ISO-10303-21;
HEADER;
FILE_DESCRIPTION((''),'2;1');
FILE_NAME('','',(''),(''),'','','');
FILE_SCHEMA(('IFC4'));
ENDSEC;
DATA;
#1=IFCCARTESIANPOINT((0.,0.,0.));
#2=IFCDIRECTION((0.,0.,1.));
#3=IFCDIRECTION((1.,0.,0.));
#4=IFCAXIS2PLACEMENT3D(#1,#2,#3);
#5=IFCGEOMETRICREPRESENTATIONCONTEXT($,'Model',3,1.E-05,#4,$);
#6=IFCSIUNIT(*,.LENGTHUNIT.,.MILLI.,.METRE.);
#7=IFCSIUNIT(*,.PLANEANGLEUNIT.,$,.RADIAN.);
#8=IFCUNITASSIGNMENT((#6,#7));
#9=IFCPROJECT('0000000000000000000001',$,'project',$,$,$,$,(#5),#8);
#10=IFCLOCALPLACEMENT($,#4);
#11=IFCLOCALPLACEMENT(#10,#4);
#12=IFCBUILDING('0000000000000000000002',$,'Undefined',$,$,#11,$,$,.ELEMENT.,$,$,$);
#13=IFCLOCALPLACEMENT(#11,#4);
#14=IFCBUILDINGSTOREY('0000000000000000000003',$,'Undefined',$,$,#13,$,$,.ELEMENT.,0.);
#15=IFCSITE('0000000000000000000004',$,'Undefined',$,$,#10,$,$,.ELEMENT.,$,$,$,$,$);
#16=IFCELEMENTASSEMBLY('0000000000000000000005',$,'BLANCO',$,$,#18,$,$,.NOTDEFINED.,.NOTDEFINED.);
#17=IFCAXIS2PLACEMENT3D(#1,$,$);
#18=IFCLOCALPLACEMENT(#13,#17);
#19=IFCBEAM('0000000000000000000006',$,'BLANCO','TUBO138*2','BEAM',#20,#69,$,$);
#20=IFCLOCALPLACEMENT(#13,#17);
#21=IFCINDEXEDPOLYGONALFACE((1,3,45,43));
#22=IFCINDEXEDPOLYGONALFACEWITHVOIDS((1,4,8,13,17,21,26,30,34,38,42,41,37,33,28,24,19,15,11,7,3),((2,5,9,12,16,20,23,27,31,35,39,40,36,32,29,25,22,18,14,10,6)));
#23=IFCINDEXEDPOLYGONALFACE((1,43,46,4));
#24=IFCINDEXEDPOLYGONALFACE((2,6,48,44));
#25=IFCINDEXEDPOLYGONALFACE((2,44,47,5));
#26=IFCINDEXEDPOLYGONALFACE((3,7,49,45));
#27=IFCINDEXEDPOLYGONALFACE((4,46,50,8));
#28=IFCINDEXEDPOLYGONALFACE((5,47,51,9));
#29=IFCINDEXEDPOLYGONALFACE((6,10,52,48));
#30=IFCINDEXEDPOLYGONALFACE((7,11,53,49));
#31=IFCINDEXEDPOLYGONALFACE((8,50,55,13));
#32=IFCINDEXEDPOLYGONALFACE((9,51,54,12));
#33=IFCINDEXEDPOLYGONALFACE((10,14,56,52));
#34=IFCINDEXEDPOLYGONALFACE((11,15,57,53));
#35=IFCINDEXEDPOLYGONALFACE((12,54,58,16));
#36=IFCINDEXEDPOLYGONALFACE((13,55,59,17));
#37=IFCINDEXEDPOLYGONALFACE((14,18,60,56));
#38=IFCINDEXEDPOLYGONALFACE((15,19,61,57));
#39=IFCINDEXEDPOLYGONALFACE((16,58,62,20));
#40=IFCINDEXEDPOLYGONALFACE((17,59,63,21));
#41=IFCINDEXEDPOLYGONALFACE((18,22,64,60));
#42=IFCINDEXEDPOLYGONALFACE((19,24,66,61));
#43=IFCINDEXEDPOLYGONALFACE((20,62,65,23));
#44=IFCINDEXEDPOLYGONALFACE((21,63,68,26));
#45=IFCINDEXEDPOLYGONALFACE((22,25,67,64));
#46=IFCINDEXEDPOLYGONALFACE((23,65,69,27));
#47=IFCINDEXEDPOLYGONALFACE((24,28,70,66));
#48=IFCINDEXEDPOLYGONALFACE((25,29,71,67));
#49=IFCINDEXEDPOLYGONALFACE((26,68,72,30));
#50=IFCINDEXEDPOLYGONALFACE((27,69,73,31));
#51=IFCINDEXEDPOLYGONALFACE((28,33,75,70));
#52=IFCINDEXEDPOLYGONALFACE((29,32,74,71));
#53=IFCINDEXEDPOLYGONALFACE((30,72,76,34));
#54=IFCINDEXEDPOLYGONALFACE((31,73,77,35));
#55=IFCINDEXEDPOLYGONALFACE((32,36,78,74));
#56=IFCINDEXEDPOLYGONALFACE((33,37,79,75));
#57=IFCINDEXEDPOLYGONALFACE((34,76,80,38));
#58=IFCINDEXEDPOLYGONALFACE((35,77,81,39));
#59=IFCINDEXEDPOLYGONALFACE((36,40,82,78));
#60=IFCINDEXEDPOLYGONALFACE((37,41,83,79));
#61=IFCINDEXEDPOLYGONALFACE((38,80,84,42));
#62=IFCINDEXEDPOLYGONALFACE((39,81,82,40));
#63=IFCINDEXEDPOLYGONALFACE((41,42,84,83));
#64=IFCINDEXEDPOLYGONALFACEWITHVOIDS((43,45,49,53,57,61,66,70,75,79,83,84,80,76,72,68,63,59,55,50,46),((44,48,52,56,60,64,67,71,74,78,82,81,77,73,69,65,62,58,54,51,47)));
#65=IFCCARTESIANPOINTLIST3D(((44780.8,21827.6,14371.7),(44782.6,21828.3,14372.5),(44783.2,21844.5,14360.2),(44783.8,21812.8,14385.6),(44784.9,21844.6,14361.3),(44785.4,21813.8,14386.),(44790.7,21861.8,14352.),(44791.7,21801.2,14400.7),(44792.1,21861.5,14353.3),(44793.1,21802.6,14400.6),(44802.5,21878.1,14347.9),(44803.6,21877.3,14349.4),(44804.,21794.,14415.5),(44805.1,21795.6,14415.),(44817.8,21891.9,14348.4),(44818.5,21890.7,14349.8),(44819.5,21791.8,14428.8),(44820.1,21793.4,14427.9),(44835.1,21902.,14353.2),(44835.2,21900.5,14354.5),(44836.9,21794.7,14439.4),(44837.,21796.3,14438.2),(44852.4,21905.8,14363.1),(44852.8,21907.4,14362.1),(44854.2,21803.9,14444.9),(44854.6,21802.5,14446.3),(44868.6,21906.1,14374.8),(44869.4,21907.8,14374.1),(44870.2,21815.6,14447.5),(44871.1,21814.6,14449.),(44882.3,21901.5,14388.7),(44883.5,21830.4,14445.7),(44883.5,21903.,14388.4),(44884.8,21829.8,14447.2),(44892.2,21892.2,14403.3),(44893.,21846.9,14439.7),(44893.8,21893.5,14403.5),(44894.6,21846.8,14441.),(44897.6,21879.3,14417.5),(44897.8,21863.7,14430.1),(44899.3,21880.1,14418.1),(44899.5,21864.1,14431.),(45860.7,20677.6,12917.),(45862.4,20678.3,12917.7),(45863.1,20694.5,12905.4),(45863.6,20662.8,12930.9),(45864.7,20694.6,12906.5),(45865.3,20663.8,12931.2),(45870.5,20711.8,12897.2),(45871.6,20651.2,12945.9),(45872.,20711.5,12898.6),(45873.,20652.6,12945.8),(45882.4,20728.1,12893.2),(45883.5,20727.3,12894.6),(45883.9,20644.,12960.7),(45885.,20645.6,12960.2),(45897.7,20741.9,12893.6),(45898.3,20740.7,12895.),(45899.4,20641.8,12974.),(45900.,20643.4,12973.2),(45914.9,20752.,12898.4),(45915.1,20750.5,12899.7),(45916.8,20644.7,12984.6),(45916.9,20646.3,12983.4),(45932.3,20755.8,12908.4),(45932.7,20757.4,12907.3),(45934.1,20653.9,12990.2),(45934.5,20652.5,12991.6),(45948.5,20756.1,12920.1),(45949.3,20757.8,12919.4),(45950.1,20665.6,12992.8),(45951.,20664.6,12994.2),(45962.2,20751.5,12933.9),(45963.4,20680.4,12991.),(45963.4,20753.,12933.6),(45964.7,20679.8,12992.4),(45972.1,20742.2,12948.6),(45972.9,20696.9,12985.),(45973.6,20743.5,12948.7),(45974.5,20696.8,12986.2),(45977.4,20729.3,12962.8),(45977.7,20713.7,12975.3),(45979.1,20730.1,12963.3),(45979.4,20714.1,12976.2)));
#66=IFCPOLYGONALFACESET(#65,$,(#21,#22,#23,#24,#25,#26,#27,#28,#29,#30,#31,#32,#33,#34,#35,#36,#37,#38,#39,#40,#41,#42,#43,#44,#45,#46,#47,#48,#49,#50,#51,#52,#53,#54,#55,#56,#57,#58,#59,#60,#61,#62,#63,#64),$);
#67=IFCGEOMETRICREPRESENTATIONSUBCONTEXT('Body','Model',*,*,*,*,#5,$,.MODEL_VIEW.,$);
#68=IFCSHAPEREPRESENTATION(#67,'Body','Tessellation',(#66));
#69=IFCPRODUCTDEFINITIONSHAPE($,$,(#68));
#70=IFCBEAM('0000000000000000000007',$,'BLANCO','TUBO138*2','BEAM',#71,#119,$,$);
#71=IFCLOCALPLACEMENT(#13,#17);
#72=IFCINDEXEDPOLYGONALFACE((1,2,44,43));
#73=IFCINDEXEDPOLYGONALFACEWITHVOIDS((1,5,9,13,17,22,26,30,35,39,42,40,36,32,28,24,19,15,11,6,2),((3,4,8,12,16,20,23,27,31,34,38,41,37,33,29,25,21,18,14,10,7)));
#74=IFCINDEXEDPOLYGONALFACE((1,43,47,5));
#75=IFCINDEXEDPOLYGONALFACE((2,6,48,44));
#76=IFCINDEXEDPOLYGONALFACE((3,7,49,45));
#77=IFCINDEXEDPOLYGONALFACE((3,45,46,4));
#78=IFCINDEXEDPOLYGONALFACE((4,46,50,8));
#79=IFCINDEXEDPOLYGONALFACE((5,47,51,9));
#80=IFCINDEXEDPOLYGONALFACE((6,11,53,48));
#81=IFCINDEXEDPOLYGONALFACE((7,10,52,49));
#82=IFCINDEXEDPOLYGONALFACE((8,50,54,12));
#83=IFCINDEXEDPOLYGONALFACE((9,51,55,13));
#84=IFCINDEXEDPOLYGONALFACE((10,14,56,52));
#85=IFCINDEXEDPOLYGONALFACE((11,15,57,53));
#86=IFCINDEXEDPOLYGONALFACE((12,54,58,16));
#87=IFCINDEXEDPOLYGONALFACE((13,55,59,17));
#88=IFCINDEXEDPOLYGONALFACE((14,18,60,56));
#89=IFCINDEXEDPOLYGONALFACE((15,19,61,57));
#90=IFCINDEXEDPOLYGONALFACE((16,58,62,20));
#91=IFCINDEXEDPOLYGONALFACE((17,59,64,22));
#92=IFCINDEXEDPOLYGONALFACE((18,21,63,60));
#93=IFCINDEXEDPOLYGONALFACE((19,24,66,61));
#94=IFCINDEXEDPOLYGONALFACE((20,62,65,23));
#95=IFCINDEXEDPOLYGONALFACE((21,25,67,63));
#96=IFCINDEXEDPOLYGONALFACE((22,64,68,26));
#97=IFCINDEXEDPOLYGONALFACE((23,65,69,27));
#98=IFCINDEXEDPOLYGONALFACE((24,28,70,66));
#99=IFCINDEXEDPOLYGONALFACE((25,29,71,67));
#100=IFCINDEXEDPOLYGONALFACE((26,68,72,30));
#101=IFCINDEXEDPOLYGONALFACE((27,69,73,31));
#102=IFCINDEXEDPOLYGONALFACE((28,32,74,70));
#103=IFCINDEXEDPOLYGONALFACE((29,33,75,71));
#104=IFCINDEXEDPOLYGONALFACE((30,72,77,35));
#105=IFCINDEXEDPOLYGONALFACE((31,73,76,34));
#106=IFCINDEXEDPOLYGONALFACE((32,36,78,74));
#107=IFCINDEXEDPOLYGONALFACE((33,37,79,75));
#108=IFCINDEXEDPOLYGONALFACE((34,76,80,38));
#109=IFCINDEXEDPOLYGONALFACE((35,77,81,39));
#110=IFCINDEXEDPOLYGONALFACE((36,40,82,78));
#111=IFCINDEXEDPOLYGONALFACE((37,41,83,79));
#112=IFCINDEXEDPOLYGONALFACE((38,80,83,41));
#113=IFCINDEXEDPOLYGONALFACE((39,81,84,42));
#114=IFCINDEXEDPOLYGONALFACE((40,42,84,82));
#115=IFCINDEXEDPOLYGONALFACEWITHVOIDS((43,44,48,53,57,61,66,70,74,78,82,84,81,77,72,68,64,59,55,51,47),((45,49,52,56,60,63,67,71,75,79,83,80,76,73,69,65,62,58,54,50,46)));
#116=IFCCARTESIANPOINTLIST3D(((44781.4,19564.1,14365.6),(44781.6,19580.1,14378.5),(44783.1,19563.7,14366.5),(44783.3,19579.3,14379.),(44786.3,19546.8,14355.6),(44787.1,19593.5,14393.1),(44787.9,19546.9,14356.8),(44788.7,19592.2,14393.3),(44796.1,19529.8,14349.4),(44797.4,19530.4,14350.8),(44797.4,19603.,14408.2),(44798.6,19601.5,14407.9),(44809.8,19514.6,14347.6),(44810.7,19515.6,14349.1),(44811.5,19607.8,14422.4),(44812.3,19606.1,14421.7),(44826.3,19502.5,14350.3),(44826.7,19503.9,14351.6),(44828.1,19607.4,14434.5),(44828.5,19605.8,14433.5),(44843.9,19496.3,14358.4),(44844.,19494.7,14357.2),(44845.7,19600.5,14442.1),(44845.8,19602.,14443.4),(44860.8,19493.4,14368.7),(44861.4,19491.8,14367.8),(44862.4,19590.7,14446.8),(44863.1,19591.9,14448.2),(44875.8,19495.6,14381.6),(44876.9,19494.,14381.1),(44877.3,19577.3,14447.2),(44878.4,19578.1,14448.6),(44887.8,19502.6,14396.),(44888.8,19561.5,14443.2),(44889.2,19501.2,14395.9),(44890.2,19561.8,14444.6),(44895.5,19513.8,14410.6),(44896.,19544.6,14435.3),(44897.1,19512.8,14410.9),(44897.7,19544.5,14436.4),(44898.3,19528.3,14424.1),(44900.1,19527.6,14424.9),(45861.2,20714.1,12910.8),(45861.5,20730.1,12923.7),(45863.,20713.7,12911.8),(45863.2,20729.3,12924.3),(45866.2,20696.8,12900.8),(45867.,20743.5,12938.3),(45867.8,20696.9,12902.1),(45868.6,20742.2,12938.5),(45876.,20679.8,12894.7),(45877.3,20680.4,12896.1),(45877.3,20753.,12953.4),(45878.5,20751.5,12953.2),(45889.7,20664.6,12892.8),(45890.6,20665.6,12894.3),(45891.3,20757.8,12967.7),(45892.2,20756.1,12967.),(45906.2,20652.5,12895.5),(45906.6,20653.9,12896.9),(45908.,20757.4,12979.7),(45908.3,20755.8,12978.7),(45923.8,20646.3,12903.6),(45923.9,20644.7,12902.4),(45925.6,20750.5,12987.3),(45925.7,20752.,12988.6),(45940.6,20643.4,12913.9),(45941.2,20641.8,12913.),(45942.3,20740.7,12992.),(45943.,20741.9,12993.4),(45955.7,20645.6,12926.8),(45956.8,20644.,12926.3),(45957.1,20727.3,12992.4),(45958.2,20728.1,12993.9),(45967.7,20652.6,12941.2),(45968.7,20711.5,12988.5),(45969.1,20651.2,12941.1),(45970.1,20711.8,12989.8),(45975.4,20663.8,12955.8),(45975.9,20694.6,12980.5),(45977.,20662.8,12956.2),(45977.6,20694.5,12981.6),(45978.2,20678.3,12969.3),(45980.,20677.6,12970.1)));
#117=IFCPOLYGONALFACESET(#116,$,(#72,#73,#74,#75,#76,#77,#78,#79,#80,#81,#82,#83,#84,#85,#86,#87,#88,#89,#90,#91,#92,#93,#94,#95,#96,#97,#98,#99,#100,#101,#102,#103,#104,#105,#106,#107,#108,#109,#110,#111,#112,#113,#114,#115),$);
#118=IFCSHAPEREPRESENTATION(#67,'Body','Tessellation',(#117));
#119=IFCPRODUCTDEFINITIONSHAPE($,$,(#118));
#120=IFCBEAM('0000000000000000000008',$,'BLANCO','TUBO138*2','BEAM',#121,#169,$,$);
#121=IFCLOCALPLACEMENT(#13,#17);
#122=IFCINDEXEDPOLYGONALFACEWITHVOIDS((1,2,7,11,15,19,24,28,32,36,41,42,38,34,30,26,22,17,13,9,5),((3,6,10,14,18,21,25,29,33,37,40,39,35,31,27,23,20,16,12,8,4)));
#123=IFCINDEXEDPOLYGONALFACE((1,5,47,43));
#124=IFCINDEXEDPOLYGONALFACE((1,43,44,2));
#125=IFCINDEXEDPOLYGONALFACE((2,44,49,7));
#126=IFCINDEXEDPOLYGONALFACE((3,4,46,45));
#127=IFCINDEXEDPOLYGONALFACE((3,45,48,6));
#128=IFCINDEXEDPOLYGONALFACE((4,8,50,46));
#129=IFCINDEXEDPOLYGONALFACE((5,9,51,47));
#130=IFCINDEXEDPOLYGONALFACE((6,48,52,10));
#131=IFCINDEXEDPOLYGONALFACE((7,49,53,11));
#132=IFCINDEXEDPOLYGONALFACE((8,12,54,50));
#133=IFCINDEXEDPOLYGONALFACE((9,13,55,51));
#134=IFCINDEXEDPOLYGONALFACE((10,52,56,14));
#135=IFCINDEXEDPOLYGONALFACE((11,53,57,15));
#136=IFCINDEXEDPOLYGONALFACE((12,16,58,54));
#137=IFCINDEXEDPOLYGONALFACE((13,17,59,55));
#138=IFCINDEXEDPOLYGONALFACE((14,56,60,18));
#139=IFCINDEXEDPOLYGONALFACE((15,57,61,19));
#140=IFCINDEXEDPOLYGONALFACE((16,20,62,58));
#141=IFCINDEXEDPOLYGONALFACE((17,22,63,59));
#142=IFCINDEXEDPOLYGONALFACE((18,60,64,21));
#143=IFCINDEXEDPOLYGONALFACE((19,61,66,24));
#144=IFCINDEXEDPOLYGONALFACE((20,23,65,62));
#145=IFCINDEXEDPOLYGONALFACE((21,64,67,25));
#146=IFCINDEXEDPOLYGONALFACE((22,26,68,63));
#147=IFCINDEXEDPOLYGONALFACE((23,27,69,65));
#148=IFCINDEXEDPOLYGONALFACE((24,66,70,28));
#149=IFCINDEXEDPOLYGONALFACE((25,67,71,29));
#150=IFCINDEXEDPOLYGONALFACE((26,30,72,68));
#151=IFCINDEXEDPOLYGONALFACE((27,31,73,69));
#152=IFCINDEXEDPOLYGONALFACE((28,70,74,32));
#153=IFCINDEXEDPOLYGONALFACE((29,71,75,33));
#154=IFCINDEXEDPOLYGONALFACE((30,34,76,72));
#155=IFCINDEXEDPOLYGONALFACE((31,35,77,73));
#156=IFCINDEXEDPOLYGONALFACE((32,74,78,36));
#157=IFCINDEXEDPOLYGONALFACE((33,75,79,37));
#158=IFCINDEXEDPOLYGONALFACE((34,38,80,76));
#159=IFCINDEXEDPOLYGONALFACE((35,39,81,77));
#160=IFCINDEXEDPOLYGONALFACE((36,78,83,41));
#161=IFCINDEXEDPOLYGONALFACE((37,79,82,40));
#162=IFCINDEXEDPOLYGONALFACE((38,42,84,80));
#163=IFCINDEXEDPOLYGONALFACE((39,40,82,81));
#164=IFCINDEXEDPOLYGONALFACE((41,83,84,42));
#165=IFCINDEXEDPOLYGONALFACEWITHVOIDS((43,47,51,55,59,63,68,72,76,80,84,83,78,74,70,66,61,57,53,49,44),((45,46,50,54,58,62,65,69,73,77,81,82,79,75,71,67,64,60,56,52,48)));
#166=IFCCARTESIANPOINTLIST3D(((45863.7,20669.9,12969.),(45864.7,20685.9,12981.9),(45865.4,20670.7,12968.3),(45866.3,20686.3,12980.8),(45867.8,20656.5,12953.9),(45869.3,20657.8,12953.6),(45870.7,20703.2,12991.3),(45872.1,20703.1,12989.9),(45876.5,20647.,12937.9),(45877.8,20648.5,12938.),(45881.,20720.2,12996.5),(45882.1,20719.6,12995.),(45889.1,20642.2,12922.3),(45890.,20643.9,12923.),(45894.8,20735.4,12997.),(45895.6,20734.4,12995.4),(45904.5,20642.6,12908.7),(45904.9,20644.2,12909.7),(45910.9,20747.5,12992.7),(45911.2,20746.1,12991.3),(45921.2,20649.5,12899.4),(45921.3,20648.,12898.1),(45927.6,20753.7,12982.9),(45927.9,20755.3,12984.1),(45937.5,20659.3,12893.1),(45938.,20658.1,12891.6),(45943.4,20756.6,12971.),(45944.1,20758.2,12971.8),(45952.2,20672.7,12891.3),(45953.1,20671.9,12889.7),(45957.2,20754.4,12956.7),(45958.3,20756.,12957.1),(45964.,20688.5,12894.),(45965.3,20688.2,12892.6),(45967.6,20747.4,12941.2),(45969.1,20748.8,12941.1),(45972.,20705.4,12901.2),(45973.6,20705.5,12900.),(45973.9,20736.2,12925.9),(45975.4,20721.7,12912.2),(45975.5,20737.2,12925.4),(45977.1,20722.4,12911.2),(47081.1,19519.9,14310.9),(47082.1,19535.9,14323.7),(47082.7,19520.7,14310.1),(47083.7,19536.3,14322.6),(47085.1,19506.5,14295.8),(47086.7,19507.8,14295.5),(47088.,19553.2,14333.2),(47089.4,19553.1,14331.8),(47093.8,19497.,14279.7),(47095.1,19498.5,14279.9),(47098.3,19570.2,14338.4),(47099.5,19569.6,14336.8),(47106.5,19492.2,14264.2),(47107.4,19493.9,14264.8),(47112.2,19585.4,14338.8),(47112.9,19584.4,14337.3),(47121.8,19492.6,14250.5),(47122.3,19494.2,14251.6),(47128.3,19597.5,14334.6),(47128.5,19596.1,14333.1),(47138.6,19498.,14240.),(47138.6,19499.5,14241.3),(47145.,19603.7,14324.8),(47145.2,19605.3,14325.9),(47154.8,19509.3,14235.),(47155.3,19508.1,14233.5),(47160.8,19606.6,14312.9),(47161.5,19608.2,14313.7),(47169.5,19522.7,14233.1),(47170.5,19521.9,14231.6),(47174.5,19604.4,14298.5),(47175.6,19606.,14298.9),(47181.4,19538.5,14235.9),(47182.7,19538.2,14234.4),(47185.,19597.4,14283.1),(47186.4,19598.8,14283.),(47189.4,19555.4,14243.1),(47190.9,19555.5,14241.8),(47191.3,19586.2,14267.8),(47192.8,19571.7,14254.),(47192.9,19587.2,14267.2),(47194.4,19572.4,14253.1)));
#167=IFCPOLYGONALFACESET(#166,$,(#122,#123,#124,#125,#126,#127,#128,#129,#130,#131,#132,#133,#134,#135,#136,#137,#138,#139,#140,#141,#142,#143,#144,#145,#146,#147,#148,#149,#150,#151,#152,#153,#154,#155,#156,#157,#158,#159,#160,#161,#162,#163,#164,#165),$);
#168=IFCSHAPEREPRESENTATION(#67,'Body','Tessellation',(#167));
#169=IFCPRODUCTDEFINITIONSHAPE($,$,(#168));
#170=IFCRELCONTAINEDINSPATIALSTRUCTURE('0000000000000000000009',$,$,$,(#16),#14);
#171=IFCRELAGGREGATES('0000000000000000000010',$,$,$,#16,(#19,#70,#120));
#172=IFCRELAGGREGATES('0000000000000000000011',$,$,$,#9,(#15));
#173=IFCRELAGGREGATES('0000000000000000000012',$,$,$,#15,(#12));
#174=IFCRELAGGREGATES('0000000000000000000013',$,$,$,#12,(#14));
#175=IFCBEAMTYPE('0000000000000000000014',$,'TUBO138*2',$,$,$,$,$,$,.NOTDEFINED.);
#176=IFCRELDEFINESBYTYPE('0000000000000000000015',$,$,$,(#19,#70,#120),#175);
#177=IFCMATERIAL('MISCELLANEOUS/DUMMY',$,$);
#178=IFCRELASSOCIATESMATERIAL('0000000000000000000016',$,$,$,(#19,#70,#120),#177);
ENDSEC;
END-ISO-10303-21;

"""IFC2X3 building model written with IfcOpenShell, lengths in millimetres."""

from ifc_helpers import new_model, si_unit, frame, origin_with_axes, origin_2d_with_axis, place, context, subcontext, project, spatial, hollow_circle, extrude, material, type_object, element, aggregate, save


model = new_model("IFC2X3")

# Units and contexts
model_context = context("Model", 3, precision=1e-05, world=origin_with_axes())
body_context = subcontext(model_context, "Body", "Model", "MODEL_VIEW")
ifc_project = project(units=[si_unit("LENGTHUNIT", "METRE", prefix="MILLI"), si_unit("PLANEANGLEUNIT", "RADIAN")], contexts=[model_context])

# Site, building, storey
site_placement = place(None, origin_with_axes())
site = spatial("IfcSite", under=ifc_project, at=site_placement, Name="Undefined", CompositionType="ELEMENT")
building_placement = place(site_placement, origin_with_axes())
building = spatial("IfcBuilding", under=site, at=building_placement, Name="Undefined", CompositionType="ELEMENT")
storey_placement = place(building_placement, origin_with_axes())
storey = spatial("IfcBuildingStorey", under=building, at=storey_placement, Name="Undefined", CompositionType="ELEMENT", Elevation=0.0)

# Element assembly, beams
assembly_placement = place(storey_placement, origin_with_axes())
assembly = element("IfcElementAssembly", 1, at=assembly_placement, inside=storey, Name="BLANCO", AssemblyPlace="NOTDEFINED", PredefinedType="NOTDEFINED")
ifc_material = material(Name="MISCELLANEOUS/DUMMY")
beam_type = type_object("IfcBeamType", Name="TUBO138*2", PredefinedType="NOTDEFINED")
beam_1_placement = place(assembly_placement, frame((45920.3, 20700.0, 12943.5), z_axis=(-0.497966, 0.461316, -0.734314), x_axis=(-0.503224, 0.535899, 0.677922)))
beam_1 = element("IfcBeam", 2, at=beam_1_placement, type_object=beam_type, material=ifc_material, Name="BLANCO", Description="TUBO138*2", ObjectType="BEAM", context=body_context, shape_type="SweptSolid", body=[
    extrude(hollow_circle(Radius=69.0, WallThickness=2.0, at=origin_2d_with_axis()), frame((2145.9, 0.0, 0.0), z_axis=(-1.0, 0.0, 0.0), x_axis=(0.0, -1.0, 0.0)), (0.0, 0.0, 1.0), 2145.9),
])
beam_2_placement = place(assembly_placement, frame((45920.3, 20700.0, 12943.5), z_axis=(-0.497966, -0.461316, -0.734314), x_axis=(-0.503224, -0.535899, 0.677922)))
beam_2 = element("IfcBeam", 3, at=beam_2_placement, type_object=beam_type, material=ifc_material, Name="BLANCO", Description="TUBO138*2", ObjectType="BEAM", context=body_context, shape_type="SweptSolid", body=[
    extrude(hollow_circle(Radius=69.0, WallThickness=2.0, at=origin_2d_with_axis()), frame((2145.9, 0.0, 0.0), z_axis=(-1.0, 0.0, 0.0), x_axis=(0.0, -1.0, 0.0)), (0.0, 0.0, 1.0), 2145.9),
])
beam_3_placement = place(assembly_placement, frame((45920.3, 20700.0, 12943.5), z_axis=(0.423552, -0.461316, -0.77961), x_axis=(0.567282, -0.535899, 0.625303)))
beam_3 = element("IfcBeam", 4, at=beam_3_placement, type_object=beam_type, material=ifc_material, Name="BLANCO", Description="TUBO138*2", ObjectType="BEAM", context=body_context, shape_type="SweptSolid", body=[
    extrude(hollow_circle(Radius=69.0, WallThickness=2.0, at=origin_2d_with_axis()), frame((2145.9, 0.0, 0.0), z_axis=(-1.0, 0.0, 0.0), x_axis=(0.0, -1.0, 0.0)), (0.0, 0.0, 1.0), 2145.9),
])
aggregate(assembly, [beam_1, beam_2, beam_3])

save(model, "model.ifc")
